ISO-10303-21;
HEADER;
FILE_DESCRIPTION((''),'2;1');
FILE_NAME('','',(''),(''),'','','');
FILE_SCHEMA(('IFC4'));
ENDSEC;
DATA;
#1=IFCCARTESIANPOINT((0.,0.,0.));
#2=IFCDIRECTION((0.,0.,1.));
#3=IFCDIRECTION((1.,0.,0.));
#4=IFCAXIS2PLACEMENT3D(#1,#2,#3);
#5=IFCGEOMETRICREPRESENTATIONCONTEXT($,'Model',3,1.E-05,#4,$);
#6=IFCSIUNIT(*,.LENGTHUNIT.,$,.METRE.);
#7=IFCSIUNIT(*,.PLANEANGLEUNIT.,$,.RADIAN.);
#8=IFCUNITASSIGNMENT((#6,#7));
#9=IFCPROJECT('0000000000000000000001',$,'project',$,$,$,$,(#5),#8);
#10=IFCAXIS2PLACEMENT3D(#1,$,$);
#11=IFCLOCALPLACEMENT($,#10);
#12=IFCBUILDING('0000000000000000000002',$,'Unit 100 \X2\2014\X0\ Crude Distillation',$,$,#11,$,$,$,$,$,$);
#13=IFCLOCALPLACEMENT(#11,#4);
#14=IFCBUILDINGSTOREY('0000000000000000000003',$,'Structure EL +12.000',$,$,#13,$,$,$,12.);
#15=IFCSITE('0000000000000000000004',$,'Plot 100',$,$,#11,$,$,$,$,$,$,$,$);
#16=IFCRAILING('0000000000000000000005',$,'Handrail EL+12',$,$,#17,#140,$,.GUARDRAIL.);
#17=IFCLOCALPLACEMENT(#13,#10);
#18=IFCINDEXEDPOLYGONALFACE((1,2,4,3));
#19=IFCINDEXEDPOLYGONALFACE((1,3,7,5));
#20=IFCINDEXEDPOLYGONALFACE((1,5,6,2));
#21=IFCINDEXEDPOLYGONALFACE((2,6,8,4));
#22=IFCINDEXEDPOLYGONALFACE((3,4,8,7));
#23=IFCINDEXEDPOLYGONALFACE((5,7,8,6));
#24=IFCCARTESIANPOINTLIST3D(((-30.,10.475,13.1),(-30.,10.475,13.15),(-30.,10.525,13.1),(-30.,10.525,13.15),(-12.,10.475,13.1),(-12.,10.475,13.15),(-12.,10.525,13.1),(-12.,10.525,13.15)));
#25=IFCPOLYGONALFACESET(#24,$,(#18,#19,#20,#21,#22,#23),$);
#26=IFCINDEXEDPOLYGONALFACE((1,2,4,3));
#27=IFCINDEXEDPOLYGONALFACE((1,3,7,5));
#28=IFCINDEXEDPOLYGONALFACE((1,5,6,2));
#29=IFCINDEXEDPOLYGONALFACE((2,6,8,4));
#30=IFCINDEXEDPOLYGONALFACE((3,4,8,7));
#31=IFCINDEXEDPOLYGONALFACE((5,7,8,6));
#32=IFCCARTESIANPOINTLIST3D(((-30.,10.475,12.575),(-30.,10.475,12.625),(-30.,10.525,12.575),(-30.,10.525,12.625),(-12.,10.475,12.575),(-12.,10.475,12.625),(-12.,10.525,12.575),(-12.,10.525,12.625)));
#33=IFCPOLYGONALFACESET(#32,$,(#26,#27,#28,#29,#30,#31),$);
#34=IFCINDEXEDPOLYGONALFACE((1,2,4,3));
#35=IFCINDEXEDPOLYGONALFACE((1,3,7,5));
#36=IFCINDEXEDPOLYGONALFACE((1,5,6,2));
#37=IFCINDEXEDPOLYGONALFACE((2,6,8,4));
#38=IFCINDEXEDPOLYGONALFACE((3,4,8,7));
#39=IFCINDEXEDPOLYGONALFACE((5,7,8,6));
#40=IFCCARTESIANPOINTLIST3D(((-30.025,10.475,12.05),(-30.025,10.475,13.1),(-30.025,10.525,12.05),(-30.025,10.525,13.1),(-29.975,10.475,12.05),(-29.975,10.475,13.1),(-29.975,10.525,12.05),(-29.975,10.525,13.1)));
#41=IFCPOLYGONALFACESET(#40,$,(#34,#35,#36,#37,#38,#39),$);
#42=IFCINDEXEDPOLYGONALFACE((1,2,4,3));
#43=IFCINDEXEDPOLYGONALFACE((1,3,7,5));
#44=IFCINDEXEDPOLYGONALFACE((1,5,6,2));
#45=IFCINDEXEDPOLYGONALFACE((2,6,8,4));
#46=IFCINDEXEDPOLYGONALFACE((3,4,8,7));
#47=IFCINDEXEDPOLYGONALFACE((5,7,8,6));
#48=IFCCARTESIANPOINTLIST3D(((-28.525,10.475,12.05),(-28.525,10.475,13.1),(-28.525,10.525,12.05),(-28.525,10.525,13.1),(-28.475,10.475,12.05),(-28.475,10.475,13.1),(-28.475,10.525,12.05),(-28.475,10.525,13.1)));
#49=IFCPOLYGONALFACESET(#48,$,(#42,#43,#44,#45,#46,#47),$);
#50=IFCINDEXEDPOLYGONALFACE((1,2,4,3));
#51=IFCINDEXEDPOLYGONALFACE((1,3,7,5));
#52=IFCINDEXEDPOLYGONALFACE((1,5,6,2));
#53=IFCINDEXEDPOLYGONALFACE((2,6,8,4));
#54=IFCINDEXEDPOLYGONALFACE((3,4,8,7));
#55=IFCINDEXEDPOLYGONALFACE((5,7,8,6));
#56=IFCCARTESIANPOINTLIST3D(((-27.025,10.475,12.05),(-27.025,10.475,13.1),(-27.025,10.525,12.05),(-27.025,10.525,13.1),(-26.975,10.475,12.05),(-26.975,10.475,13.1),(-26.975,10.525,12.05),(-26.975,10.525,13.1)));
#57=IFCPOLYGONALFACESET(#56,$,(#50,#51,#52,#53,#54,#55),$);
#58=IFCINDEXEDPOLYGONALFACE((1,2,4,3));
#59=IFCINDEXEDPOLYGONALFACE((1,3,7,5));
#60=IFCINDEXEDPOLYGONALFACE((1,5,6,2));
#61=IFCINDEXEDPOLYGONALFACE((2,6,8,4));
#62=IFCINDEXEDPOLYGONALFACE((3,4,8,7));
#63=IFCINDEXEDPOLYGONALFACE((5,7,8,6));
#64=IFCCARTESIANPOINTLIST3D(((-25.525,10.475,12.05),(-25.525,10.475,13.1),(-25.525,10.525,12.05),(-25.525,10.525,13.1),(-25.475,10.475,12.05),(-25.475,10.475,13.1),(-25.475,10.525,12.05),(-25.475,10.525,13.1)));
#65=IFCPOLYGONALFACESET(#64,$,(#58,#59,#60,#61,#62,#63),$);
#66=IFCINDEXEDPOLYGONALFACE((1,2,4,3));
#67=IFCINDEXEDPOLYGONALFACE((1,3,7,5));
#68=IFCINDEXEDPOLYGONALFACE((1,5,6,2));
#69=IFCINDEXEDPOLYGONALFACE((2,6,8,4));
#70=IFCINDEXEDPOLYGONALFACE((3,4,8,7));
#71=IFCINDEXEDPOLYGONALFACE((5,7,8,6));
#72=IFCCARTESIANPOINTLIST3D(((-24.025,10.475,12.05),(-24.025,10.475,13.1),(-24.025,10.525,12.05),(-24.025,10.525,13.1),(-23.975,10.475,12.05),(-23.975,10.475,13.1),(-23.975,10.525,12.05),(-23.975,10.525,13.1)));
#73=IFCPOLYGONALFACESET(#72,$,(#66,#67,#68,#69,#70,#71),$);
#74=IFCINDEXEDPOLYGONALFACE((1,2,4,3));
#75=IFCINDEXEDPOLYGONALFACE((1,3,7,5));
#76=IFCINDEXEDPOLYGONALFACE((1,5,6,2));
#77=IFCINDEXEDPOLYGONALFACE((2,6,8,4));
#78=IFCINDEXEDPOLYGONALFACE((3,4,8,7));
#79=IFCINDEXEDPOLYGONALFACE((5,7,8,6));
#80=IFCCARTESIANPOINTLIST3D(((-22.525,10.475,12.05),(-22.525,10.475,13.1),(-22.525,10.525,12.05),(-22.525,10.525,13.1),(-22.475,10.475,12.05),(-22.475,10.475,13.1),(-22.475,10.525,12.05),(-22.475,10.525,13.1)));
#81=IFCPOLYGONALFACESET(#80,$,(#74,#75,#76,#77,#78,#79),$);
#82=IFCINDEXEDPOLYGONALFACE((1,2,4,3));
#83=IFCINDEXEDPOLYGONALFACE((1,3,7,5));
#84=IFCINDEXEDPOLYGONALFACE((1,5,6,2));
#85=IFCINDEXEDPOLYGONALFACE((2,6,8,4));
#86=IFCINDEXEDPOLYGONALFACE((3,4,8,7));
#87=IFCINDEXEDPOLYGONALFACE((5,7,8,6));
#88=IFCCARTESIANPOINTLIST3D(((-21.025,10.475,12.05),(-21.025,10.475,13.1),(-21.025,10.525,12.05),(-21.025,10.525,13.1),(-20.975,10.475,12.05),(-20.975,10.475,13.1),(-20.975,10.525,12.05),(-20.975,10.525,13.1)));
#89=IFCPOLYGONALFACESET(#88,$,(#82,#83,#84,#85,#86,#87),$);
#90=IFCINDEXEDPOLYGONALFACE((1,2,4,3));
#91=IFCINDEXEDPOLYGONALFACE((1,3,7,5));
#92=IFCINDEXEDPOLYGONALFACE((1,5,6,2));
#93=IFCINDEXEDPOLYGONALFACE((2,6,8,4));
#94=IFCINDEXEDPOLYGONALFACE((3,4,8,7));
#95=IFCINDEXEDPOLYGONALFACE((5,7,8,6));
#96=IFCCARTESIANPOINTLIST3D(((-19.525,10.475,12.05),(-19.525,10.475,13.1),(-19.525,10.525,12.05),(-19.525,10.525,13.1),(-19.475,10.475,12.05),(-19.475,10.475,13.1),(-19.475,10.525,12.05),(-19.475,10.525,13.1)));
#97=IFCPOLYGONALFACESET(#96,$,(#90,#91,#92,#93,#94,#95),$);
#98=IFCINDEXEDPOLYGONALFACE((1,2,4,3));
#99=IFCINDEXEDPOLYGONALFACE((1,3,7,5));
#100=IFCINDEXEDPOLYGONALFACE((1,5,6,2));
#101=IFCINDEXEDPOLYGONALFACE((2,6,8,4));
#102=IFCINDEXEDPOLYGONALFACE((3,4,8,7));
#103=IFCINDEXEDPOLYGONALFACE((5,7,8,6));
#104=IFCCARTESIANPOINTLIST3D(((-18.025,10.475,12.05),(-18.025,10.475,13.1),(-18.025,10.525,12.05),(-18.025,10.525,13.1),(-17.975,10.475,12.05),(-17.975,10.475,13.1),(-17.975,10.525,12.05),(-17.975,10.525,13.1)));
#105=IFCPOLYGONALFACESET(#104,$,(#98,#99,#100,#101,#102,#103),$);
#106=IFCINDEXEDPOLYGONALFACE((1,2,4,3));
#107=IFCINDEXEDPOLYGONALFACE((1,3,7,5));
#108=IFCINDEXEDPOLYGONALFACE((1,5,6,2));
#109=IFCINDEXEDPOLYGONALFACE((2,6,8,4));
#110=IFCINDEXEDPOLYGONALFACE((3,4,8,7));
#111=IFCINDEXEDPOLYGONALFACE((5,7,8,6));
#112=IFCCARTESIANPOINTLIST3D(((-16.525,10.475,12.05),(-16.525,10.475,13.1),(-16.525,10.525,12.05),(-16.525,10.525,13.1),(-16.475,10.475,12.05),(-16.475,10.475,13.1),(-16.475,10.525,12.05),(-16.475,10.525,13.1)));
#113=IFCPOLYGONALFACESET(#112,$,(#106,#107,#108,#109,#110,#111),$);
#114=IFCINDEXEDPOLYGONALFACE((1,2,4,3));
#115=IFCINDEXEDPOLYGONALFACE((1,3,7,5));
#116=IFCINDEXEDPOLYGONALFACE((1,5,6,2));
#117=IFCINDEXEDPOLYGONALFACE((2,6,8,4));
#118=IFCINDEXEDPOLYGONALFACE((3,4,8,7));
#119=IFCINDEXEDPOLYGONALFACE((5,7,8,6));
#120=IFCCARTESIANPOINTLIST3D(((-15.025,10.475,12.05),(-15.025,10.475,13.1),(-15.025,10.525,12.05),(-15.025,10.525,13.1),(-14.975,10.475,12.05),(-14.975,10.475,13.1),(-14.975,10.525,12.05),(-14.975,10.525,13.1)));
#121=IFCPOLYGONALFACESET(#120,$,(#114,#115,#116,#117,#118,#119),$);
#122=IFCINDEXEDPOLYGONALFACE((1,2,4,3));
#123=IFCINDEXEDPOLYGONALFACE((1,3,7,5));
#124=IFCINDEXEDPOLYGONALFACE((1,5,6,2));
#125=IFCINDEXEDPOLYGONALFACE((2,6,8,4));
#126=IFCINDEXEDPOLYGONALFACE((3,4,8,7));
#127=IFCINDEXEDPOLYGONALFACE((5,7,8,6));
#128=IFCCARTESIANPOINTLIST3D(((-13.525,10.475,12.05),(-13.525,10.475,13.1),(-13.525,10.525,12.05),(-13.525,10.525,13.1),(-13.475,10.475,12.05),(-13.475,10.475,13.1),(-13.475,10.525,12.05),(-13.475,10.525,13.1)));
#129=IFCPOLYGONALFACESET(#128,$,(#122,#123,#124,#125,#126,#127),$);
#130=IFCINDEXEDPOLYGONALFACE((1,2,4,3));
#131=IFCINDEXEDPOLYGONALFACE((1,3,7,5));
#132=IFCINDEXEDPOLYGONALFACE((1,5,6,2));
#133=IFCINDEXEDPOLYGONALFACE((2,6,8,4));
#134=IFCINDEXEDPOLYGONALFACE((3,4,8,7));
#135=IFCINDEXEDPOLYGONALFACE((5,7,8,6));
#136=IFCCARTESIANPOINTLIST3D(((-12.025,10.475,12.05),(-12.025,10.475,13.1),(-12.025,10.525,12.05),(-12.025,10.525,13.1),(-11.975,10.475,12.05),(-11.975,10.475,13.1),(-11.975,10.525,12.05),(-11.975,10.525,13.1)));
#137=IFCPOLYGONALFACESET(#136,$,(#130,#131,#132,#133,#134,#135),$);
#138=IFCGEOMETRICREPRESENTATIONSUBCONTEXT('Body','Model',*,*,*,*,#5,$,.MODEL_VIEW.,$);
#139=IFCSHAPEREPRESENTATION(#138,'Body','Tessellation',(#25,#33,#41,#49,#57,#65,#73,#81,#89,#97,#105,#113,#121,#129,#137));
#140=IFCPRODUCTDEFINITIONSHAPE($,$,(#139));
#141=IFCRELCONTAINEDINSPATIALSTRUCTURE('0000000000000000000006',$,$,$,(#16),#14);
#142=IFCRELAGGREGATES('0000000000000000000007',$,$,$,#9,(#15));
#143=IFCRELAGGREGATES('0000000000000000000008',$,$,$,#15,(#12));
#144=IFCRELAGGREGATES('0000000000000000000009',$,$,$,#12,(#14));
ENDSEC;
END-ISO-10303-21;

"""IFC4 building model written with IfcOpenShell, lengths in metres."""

from ifc_helpers import new_model, si_unit, frame, origin, origin_with_axes, origin_2d, place, context, subcontext, project, spatial, rectangle, extrude, element, save


model = new_model("IFC4")

# Units and contexts
model_context = context("Model", 3, precision=1e-05, world=origin_with_axes())
body_context = subcontext(model_context, "Body", "Model", "MODEL_VIEW")
ifc_project = project(units=[si_unit("LENGTHUNIT", "METRE"), si_unit("PLANEANGLEUNIT", "RADIAN")], contexts=[model_context])

# Site, building, storey
placement = place(None, origin())
site = spatial("IfcSite", under=ifc_project, at=placement, Name="Plot 100")
building = spatial("IfcBuilding", under=site, at=placement, Name="Unit 100 — Crude Distillation")
storey_placement = place(placement, origin_with_axes())
storey = spatial("IfcBuildingStorey", under=building, at=storey_placement, Name="Structure EL +12.000", Elevation=12.0)

# Railing
railing_1_placement = place(storey_placement, origin_with_axes())
element("IfcRailing", 1, at=railing_1_placement, inside=storey, Name="Handrail EL+12", PredefinedType="GUARDRAIL", context=body_context, shape_type="SweptSolid", body=[
    extrude(rectangle(XDim=0.05, YDim=0.05, at=origin_2d()), frame((-30.0, 10.5, 13.125), z_axis=(1.0, 0.0, 0.0), x_axis=(0.0, 1.0, 0.0)), (0.0, 0.0, 1.0), 18.0),
    extrude(rectangle(XDim=0.05, YDim=0.05, at=origin_2d()), frame((-30.0, 10.5, 12.6), z_axis=(1.0, 0.0, 0.0), x_axis=(0.0, 1.0, 0.0)), (0.0, 0.0, 1.0), 18.0),
    extrude(rectangle(XDim=0.05, YDim=0.05, at=origin_2d()), frame((-30.0, 10.5, 12.05), z_axis=(0.0, 0.0, 1.0), x_axis=(1.0, 0.0, 0.0)), (0.0, 0.0, 1.0), 1.05),
    extrude(rectangle(XDim=0.05, YDim=0.05, at=origin_2d()), frame((-28.5, 10.5, 12.05), z_axis=(0.0, 0.0, 1.0), x_axis=(1.0, 0.0, 0.0)), (0.0, 0.0, 1.0), 1.05),
    extrude(rectangle(XDim=0.05, YDim=0.05, at=origin_2d()), frame((-27.0, 10.5, 12.05), z_axis=(0.0, 0.0, 1.0), x_axis=(1.0, 0.0, 0.0)), (0.0, 0.0, 1.0), 1.05),
    extrude(rectangle(XDim=0.05, YDim=0.05, at=origin_2d()), frame((-25.5, 10.5, 12.05), z_axis=(0.0, 0.0, 1.0), x_axis=(1.0, 0.0, 0.0)), (0.0, 0.0, 1.0), 1.05),
    extrude(rectangle(XDim=0.05, YDim=0.05, at=origin_2d()), frame((-24.0, 10.5, 12.05), z_axis=(0.0, 0.0, 1.0), x_axis=(1.0, 0.0, 0.0)), (0.0, 0.0, 1.0), 1.05),
    extrude(rectangle(XDim=0.05, YDim=0.05, at=origin_2d()), frame((-22.5, 10.5, 12.05), z_axis=(0.0, 0.0, 1.0), x_axis=(1.0, 0.0, 0.0)), (0.0, 0.0, 1.0), 1.05),
    extrude(rectangle(XDim=0.05, YDim=0.05, at=origin_2d()), frame((-21.0, 10.5, 12.05), z_axis=(0.0, 0.0, 1.0), x_axis=(1.0, 0.0, 0.0)), (0.0, 0.0, 1.0), 1.05),
    extrude(rectangle(XDim=0.05, YDim=0.05, at=origin_2d()), frame((-19.5, 10.5, 12.05), z_axis=(0.0, 0.0, 1.0), x_axis=(1.0, 0.0, 0.0)), (0.0, 0.0, 1.0), 1.05),
    extrude(rectangle(XDim=0.05, YDim=0.05, at=origin_2d()), frame((-18.0, 10.5, 12.05), z_axis=(0.0, 0.0, 1.0), x_axis=(1.0, 0.0, 0.0)), (0.0, 0.0, 1.0), 1.05),
    extrude(rectangle(XDim=0.05, YDim=0.05, at=origin_2d()), frame((-16.5, 10.5, 12.05), z_axis=(0.0, 0.0, 1.0), x_axis=(1.0, 0.0, 0.0)), (0.0, 0.0, 1.0), 1.05),
    extrude(rectangle(XDim=0.05, YDim=0.05, at=origin_2d()), frame((-15.0, 10.5, 12.05), z_axis=(0.0, 0.0, 1.0), x_axis=(1.0, 0.0, 0.0)), (0.0, 0.0, 1.0), 1.05),
    extrude(rectangle(XDim=0.05, YDim=0.05, at=origin_2d()), frame((-13.5, 10.5, 12.05), z_axis=(0.0, 0.0, 1.0), x_axis=(1.0, 0.0, 0.0)), (0.0, 0.0, 1.0), 1.05),
    extrude(rectangle(XDim=0.05, YDim=0.05, at=origin_2d()), frame((-12.0, 10.5, 12.05), z_axis=(0.0, 0.0, 1.0), x_axis=(1.0, 0.0, 0.0)), (0.0, 0.0, 1.0), 1.05),
])

save(model, "model.ifc")
